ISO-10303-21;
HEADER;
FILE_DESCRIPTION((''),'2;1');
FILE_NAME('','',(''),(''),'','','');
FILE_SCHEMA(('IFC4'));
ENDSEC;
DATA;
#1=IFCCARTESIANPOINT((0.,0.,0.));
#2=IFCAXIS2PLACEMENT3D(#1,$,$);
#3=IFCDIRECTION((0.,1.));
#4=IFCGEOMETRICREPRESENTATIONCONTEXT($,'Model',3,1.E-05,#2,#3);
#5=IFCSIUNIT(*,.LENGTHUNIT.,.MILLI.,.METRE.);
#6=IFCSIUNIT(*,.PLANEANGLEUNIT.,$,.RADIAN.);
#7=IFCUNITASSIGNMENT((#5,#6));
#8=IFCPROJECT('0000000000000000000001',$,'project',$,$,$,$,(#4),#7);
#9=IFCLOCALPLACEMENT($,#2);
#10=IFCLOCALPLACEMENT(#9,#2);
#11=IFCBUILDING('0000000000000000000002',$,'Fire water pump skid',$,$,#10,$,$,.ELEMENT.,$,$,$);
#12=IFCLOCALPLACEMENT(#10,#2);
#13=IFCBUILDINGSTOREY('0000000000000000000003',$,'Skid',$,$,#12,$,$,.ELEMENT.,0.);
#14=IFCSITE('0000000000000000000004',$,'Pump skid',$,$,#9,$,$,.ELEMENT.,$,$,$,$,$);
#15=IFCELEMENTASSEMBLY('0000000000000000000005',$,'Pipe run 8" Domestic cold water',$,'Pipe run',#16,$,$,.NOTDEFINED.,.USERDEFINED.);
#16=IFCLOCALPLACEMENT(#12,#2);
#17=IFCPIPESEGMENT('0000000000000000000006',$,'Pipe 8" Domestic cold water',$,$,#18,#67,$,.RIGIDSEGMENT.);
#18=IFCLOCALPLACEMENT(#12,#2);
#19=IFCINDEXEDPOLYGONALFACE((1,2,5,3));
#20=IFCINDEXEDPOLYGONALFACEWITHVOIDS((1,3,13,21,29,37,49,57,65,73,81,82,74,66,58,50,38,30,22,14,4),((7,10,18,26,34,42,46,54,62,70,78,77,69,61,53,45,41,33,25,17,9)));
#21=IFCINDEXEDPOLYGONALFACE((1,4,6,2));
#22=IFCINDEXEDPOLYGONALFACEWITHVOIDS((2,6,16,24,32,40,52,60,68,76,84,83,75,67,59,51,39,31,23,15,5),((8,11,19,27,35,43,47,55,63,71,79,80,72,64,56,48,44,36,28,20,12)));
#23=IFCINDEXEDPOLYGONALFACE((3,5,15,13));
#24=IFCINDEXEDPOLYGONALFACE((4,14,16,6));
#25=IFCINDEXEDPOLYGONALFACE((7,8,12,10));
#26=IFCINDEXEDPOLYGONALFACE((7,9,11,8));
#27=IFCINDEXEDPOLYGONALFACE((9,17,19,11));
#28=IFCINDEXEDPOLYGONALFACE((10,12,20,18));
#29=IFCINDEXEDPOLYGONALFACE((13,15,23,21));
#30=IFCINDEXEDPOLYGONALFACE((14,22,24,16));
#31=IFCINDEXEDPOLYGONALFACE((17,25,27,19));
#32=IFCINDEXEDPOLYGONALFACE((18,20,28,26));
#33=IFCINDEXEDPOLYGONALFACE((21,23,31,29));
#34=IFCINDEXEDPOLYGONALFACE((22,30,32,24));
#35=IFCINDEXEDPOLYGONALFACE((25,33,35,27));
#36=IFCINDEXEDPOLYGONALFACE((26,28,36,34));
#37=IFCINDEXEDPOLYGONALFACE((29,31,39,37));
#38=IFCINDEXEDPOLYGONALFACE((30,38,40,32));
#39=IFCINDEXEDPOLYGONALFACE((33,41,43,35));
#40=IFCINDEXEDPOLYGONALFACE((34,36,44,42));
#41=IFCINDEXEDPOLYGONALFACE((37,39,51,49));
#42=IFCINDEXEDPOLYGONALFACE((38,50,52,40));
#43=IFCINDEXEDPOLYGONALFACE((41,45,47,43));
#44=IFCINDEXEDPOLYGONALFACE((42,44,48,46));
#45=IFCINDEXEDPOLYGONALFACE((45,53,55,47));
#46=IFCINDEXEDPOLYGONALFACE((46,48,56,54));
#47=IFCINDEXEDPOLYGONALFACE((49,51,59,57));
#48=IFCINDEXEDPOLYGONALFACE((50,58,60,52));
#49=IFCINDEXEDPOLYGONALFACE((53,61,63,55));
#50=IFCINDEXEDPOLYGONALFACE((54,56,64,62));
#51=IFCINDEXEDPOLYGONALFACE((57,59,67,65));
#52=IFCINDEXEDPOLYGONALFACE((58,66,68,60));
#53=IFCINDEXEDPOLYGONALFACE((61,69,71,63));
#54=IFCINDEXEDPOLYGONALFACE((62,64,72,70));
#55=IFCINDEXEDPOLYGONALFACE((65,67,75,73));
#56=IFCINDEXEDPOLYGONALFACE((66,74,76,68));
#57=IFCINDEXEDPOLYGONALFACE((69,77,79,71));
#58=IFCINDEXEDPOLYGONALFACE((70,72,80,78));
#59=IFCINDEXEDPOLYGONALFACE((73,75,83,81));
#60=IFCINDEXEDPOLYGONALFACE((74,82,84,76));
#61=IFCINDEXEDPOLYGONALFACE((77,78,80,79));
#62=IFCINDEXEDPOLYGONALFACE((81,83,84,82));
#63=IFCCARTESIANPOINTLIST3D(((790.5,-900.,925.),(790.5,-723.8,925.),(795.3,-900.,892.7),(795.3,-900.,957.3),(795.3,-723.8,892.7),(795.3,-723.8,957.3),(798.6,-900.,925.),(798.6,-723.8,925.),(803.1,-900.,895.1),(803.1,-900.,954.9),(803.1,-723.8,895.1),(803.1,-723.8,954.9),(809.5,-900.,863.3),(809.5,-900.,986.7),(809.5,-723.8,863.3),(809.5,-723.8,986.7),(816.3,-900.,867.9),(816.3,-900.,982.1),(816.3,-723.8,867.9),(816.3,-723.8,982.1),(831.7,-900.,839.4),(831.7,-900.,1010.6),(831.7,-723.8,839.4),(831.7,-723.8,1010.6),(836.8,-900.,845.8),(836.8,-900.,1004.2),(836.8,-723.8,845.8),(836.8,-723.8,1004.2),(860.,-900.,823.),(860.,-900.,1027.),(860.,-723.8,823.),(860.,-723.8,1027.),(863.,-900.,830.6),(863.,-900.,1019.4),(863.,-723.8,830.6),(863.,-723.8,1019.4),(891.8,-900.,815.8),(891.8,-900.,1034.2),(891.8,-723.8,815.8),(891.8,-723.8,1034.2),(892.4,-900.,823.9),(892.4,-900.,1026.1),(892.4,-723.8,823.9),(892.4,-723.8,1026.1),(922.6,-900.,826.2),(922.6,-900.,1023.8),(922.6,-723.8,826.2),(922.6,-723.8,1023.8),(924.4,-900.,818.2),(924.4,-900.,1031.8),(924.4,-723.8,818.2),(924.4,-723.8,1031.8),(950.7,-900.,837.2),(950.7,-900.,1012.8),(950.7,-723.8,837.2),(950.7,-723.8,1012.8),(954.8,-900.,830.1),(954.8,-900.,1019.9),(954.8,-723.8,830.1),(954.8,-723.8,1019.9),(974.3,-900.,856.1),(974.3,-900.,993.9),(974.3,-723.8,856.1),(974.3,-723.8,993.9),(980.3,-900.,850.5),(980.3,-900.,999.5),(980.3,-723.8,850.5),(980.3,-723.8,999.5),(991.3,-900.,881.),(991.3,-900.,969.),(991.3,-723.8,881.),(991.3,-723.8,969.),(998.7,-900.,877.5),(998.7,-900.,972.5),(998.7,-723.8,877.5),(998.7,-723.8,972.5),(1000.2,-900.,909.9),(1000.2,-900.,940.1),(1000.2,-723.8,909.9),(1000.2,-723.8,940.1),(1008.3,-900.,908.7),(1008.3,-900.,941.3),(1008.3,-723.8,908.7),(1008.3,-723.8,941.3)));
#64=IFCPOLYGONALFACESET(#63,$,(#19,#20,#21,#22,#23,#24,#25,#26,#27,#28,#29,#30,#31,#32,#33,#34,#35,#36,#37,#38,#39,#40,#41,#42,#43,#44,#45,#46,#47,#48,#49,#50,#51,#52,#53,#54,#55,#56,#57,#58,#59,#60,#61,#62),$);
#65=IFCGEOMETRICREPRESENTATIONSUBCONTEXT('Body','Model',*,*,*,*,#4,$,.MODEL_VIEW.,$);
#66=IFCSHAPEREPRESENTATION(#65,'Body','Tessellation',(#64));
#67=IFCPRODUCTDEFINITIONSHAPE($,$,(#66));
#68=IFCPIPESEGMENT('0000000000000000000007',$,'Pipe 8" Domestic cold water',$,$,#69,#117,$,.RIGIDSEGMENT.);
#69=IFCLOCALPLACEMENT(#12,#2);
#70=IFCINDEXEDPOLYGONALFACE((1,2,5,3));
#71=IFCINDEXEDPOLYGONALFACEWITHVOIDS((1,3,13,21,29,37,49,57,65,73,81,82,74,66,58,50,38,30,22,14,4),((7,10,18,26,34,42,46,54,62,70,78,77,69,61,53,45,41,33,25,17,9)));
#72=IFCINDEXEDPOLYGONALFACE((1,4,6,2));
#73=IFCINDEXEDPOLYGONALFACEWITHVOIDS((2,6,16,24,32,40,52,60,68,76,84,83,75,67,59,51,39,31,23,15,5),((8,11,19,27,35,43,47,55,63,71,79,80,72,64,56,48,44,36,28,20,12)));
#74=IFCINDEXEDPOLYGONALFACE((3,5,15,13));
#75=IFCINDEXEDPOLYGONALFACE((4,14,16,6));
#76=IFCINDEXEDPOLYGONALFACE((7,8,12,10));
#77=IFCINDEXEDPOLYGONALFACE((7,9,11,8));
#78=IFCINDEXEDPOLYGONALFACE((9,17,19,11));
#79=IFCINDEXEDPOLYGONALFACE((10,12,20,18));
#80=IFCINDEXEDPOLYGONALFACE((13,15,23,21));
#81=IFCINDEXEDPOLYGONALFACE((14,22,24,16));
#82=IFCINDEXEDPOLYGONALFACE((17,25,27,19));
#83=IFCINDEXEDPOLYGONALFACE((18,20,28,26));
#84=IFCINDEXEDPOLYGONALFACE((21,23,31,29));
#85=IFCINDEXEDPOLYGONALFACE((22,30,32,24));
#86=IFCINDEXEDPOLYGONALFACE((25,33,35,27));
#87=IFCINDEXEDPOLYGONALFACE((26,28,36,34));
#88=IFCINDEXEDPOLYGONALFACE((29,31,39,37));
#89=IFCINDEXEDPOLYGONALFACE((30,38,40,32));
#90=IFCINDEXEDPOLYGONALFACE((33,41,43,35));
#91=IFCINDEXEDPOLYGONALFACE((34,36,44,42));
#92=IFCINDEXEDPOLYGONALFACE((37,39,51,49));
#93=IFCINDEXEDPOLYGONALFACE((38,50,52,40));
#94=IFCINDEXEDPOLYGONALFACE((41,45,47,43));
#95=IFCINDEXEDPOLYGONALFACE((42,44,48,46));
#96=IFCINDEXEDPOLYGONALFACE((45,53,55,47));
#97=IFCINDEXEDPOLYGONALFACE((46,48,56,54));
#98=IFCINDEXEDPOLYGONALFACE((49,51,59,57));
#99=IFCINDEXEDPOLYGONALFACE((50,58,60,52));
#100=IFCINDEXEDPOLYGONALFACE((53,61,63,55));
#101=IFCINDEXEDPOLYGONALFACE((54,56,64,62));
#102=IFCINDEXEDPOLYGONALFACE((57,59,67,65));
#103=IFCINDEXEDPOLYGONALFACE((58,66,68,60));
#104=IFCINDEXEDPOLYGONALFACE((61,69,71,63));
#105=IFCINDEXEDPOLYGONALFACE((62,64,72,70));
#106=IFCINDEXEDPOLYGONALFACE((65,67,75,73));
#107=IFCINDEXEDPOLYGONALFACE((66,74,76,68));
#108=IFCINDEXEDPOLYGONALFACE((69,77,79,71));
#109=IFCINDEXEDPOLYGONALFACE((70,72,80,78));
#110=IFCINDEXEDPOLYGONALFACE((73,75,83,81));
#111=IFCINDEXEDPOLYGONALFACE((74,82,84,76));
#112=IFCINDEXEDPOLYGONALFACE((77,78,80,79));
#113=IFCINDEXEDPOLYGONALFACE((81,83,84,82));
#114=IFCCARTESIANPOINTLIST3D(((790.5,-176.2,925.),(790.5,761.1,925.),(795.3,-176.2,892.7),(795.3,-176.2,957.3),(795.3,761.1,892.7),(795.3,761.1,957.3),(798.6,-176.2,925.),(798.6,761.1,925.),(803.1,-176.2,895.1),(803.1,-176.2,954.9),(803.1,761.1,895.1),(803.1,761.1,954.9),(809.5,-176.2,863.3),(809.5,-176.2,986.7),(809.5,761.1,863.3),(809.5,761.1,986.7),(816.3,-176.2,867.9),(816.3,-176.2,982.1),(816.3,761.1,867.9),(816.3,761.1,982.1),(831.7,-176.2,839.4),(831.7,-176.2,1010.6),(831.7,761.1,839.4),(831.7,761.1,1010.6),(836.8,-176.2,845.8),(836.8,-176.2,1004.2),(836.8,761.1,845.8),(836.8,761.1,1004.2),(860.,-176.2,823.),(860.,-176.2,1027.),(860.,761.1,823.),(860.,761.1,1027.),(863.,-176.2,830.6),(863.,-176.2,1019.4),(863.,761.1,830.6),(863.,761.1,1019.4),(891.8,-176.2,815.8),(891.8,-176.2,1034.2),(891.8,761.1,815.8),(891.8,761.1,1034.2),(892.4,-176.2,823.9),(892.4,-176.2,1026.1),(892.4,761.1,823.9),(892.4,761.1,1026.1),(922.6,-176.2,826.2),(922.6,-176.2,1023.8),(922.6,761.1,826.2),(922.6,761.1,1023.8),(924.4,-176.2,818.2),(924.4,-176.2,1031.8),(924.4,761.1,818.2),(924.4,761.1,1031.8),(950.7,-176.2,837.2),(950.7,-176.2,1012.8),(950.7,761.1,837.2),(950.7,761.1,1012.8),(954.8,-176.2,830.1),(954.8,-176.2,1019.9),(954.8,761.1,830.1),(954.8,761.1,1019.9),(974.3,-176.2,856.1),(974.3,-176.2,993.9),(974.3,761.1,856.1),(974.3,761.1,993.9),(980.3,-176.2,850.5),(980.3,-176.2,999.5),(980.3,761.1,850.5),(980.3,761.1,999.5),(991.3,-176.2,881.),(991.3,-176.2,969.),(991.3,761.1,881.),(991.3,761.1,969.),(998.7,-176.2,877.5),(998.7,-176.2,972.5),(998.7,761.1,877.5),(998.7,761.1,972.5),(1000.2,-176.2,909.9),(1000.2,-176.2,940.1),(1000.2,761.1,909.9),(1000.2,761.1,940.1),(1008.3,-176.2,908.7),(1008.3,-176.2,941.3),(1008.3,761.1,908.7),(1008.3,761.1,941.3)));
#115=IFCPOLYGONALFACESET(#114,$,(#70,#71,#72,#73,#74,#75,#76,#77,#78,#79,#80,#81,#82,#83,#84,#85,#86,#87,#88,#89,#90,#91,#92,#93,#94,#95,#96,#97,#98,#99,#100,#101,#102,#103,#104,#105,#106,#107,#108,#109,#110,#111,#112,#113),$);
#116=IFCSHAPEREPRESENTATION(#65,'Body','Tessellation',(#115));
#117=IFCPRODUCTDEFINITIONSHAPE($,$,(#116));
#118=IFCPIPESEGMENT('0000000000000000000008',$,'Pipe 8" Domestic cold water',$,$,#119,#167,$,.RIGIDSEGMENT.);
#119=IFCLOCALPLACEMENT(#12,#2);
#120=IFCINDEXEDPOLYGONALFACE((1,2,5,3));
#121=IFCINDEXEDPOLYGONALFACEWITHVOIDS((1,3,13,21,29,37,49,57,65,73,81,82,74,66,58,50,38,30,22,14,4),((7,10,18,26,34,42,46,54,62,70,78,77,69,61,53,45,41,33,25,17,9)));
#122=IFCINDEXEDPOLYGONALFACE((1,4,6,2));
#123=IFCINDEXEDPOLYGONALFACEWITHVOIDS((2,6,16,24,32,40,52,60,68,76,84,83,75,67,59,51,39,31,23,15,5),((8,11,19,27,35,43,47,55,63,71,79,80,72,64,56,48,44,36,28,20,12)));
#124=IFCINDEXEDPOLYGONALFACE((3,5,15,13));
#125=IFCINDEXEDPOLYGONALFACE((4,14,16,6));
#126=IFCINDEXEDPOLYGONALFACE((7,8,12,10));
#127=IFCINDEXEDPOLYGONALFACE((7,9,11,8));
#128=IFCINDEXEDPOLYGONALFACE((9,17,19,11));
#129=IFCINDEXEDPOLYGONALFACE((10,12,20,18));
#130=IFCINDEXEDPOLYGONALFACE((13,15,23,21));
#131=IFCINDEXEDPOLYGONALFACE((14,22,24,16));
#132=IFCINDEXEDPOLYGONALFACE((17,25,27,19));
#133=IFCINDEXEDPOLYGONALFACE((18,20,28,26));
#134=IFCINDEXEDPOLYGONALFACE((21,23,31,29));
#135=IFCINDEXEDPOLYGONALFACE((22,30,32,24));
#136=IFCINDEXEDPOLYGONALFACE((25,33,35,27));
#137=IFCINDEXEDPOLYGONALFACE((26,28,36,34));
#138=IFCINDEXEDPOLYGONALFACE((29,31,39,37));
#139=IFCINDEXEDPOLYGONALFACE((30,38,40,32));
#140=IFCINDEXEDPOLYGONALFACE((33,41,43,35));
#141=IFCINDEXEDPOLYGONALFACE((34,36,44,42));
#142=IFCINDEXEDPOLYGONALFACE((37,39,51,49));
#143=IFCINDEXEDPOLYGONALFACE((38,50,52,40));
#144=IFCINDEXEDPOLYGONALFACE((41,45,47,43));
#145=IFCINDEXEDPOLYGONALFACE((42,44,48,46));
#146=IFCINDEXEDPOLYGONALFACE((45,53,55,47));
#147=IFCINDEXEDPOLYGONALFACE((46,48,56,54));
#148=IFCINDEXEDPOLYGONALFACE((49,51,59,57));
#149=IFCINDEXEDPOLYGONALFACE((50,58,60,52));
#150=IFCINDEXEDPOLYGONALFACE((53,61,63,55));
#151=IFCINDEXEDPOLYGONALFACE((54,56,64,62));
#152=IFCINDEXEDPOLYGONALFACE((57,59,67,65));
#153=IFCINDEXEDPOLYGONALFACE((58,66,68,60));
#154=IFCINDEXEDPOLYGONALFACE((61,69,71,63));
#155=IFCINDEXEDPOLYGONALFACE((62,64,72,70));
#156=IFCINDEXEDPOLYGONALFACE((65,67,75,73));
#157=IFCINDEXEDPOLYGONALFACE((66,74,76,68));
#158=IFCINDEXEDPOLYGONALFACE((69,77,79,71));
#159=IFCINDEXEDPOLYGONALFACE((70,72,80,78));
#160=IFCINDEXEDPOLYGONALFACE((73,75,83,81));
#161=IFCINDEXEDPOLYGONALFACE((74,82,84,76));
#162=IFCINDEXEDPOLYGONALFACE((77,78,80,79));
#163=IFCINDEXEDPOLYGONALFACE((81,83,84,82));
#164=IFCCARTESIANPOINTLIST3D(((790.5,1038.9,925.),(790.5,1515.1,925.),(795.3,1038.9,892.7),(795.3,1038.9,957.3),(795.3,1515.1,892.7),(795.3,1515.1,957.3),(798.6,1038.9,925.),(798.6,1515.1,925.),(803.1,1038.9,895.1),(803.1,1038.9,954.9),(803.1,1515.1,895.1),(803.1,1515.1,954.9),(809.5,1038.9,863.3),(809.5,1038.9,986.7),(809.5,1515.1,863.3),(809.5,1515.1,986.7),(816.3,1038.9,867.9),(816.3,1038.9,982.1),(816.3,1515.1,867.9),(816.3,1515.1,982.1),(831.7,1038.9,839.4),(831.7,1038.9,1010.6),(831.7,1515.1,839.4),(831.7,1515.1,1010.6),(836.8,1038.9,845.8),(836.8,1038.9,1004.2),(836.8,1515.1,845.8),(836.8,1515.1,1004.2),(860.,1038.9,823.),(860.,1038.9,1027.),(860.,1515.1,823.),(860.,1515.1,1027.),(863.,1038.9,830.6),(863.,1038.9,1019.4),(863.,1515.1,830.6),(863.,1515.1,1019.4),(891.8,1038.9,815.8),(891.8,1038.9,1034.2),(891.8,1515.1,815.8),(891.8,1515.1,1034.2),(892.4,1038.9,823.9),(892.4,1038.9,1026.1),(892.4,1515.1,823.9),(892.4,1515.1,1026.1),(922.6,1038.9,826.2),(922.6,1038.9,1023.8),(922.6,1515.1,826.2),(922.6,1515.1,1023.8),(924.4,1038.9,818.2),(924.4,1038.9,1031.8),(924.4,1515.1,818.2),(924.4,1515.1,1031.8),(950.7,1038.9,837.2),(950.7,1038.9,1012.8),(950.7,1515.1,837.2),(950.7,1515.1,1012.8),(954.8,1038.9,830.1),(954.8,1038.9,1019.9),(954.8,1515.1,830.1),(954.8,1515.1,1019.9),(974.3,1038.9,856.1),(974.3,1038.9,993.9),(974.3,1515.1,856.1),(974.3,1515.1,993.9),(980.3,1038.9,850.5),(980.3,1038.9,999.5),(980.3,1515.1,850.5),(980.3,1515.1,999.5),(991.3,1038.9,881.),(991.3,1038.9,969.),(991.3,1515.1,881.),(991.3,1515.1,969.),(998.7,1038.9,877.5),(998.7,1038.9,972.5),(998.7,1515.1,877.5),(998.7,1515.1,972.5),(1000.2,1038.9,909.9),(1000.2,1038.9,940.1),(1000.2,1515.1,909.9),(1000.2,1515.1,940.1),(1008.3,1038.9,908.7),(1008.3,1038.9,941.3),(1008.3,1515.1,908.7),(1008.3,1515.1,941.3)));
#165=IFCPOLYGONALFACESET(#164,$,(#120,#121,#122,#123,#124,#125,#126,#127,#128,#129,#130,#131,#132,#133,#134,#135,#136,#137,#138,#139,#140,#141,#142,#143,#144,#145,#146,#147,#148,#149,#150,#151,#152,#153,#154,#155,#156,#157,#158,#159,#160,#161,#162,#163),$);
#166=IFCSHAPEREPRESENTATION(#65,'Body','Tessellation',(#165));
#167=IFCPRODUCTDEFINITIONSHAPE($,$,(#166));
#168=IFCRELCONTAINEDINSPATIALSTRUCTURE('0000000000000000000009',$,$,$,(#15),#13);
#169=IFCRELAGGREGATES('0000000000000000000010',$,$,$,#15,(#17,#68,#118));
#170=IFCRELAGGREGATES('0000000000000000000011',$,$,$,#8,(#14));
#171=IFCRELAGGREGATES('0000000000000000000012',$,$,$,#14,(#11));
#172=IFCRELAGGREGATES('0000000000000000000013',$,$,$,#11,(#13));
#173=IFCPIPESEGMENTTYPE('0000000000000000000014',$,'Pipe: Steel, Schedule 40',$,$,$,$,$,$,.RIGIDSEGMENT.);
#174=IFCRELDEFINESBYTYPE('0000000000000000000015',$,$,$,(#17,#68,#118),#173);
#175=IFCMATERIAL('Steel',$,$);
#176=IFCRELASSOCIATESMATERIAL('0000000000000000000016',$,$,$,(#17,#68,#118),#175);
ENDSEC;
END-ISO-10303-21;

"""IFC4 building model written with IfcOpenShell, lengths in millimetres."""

from ifc_helpers import new_model, si_unit, direction, frame, origin, origin_with_axes, origin_2d, place, context, subcontext, project, spatial, hollow_circle, extrude, material, type_object, element, aggregate, save


model = new_model("IFC4")

# Units and contexts
model_context = context("Model", 3, precision=1e-05, world=origin(), true_north=direction((0.0, 1.0)))
body_context = subcontext(model_context, "Body", "Model", "MODEL_VIEW")
ifc_project = project(units=[si_unit("LENGTHUNIT", "METRE", prefix="MILLI"), si_unit("PLANEANGLEUNIT", "RADIAN")], contexts=[model_context])

# Site, building, storey
site_placement = place(None, origin())
site = spatial("IfcSite", under=ifc_project, at=site_placement, Name="Pump skid", CompositionType="ELEMENT")
building_placement = place(site_placement, origin())
building = spatial("IfcBuilding", under=site, at=building_placement, Name="Fire water pump skid", CompositionType="ELEMENT")
storey_placement = place(building_placement, origin())
storey = spatial("IfcBuildingStorey", under=building, at=storey_placement, Name="Skid", CompositionType="ELEMENT", Elevation=0.0)

# Element assembly, pipe segments
ifc_material = material(Name="Steel")
pipe_segment_type = type_object("IfcPipeSegmentType", Name="Pipe: Steel, Schedule 40", PredefinedType="RIGIDSEGMENT")
assembly_1_placement = place(storey_placement, origin_with_axes())
assembly_1 = element("IfcElementAssembly", 1, at=assembly_1_placement, inside=storey, Name="Pipe run 8\" Domestic cold water", ObjectType="Pipe run", AssemblyPlace="NOTDEFINED", PredefinedType="USERDEFINED")
pipe_segment_1_placement = place(storey_placement, origin_with_axes())
pipe_segment_1 = element("IfcPipeSegment", 2, at=pipe_segment_1_placement, type_object=pipe_segment_type, material=ifc_material, Name="Pipe 8\" Domestic cold water", PredefinedType="RIGIDSEGMENT", context=body_context, shape_type="SweptSolid", body=[
    extrude(hollow_circle(Radius=109.5, WallThickness=8.2, at=origin_2d()), frame((900.0, -900.0, 925.0), z_axis=(0.0, 1.0, 0.0), x_axis=(-1.0, 0.0, 0.0)), (0.0, 0.0, 1.0), 176.2),
])
pipe_segment_2_placement = place(storey_placement, origin_with_axes())
pipe_segment_2 = element("IfcPipeSegment", 3, at=pipe_segment_2_placement, type_object=pipe_segment_type, material=ifc_material, Name="Pipe 8\" Domestic cold water", PredefinedType="RIGIDSEGMENT", context=body_context, shape_type="SweptSolid", body=[
    extrude(hollow_circle(Radius=109.5, WallThickness=8.2, at=origin_2d()), frame((900.0, -176.2, 925.0), z_axis=(0.0, 1.0, 0.0), x_axis=(-1.0, 0.0, 0.0)), (0.0, 0.0, 1.0), 937.2),
])
pipe_segment_3_placement = place(storey_placement, origin_with_axes())
pipe_segment_3 = element("IfcPipeSegment", 4, at=pipe_segment_3_placement, type_object=pipe_segment_type, material=ifc_material, Name="Pipe 8\" Domestic cold water", PredefinedType="RIGIDSEGMENT", context=body_context, shape_type="SweptSolid", body=[
    extrude(hollow_circle(Radius=109.5, WallThickness=8.2, at=origin_2d()), frame((900.0, 1038.9, 925.0), z_axis=(0.0, 1.0, 0.0), x_axis=(-1.0, 0.0, 0.0)), (0.0, 0.0, 1.0), 476.2),
])

aggregate(assembly_1, [pipe_segment_1, pipe_segment_2, pipe_segment_3])

save(model, "model.ifc")
